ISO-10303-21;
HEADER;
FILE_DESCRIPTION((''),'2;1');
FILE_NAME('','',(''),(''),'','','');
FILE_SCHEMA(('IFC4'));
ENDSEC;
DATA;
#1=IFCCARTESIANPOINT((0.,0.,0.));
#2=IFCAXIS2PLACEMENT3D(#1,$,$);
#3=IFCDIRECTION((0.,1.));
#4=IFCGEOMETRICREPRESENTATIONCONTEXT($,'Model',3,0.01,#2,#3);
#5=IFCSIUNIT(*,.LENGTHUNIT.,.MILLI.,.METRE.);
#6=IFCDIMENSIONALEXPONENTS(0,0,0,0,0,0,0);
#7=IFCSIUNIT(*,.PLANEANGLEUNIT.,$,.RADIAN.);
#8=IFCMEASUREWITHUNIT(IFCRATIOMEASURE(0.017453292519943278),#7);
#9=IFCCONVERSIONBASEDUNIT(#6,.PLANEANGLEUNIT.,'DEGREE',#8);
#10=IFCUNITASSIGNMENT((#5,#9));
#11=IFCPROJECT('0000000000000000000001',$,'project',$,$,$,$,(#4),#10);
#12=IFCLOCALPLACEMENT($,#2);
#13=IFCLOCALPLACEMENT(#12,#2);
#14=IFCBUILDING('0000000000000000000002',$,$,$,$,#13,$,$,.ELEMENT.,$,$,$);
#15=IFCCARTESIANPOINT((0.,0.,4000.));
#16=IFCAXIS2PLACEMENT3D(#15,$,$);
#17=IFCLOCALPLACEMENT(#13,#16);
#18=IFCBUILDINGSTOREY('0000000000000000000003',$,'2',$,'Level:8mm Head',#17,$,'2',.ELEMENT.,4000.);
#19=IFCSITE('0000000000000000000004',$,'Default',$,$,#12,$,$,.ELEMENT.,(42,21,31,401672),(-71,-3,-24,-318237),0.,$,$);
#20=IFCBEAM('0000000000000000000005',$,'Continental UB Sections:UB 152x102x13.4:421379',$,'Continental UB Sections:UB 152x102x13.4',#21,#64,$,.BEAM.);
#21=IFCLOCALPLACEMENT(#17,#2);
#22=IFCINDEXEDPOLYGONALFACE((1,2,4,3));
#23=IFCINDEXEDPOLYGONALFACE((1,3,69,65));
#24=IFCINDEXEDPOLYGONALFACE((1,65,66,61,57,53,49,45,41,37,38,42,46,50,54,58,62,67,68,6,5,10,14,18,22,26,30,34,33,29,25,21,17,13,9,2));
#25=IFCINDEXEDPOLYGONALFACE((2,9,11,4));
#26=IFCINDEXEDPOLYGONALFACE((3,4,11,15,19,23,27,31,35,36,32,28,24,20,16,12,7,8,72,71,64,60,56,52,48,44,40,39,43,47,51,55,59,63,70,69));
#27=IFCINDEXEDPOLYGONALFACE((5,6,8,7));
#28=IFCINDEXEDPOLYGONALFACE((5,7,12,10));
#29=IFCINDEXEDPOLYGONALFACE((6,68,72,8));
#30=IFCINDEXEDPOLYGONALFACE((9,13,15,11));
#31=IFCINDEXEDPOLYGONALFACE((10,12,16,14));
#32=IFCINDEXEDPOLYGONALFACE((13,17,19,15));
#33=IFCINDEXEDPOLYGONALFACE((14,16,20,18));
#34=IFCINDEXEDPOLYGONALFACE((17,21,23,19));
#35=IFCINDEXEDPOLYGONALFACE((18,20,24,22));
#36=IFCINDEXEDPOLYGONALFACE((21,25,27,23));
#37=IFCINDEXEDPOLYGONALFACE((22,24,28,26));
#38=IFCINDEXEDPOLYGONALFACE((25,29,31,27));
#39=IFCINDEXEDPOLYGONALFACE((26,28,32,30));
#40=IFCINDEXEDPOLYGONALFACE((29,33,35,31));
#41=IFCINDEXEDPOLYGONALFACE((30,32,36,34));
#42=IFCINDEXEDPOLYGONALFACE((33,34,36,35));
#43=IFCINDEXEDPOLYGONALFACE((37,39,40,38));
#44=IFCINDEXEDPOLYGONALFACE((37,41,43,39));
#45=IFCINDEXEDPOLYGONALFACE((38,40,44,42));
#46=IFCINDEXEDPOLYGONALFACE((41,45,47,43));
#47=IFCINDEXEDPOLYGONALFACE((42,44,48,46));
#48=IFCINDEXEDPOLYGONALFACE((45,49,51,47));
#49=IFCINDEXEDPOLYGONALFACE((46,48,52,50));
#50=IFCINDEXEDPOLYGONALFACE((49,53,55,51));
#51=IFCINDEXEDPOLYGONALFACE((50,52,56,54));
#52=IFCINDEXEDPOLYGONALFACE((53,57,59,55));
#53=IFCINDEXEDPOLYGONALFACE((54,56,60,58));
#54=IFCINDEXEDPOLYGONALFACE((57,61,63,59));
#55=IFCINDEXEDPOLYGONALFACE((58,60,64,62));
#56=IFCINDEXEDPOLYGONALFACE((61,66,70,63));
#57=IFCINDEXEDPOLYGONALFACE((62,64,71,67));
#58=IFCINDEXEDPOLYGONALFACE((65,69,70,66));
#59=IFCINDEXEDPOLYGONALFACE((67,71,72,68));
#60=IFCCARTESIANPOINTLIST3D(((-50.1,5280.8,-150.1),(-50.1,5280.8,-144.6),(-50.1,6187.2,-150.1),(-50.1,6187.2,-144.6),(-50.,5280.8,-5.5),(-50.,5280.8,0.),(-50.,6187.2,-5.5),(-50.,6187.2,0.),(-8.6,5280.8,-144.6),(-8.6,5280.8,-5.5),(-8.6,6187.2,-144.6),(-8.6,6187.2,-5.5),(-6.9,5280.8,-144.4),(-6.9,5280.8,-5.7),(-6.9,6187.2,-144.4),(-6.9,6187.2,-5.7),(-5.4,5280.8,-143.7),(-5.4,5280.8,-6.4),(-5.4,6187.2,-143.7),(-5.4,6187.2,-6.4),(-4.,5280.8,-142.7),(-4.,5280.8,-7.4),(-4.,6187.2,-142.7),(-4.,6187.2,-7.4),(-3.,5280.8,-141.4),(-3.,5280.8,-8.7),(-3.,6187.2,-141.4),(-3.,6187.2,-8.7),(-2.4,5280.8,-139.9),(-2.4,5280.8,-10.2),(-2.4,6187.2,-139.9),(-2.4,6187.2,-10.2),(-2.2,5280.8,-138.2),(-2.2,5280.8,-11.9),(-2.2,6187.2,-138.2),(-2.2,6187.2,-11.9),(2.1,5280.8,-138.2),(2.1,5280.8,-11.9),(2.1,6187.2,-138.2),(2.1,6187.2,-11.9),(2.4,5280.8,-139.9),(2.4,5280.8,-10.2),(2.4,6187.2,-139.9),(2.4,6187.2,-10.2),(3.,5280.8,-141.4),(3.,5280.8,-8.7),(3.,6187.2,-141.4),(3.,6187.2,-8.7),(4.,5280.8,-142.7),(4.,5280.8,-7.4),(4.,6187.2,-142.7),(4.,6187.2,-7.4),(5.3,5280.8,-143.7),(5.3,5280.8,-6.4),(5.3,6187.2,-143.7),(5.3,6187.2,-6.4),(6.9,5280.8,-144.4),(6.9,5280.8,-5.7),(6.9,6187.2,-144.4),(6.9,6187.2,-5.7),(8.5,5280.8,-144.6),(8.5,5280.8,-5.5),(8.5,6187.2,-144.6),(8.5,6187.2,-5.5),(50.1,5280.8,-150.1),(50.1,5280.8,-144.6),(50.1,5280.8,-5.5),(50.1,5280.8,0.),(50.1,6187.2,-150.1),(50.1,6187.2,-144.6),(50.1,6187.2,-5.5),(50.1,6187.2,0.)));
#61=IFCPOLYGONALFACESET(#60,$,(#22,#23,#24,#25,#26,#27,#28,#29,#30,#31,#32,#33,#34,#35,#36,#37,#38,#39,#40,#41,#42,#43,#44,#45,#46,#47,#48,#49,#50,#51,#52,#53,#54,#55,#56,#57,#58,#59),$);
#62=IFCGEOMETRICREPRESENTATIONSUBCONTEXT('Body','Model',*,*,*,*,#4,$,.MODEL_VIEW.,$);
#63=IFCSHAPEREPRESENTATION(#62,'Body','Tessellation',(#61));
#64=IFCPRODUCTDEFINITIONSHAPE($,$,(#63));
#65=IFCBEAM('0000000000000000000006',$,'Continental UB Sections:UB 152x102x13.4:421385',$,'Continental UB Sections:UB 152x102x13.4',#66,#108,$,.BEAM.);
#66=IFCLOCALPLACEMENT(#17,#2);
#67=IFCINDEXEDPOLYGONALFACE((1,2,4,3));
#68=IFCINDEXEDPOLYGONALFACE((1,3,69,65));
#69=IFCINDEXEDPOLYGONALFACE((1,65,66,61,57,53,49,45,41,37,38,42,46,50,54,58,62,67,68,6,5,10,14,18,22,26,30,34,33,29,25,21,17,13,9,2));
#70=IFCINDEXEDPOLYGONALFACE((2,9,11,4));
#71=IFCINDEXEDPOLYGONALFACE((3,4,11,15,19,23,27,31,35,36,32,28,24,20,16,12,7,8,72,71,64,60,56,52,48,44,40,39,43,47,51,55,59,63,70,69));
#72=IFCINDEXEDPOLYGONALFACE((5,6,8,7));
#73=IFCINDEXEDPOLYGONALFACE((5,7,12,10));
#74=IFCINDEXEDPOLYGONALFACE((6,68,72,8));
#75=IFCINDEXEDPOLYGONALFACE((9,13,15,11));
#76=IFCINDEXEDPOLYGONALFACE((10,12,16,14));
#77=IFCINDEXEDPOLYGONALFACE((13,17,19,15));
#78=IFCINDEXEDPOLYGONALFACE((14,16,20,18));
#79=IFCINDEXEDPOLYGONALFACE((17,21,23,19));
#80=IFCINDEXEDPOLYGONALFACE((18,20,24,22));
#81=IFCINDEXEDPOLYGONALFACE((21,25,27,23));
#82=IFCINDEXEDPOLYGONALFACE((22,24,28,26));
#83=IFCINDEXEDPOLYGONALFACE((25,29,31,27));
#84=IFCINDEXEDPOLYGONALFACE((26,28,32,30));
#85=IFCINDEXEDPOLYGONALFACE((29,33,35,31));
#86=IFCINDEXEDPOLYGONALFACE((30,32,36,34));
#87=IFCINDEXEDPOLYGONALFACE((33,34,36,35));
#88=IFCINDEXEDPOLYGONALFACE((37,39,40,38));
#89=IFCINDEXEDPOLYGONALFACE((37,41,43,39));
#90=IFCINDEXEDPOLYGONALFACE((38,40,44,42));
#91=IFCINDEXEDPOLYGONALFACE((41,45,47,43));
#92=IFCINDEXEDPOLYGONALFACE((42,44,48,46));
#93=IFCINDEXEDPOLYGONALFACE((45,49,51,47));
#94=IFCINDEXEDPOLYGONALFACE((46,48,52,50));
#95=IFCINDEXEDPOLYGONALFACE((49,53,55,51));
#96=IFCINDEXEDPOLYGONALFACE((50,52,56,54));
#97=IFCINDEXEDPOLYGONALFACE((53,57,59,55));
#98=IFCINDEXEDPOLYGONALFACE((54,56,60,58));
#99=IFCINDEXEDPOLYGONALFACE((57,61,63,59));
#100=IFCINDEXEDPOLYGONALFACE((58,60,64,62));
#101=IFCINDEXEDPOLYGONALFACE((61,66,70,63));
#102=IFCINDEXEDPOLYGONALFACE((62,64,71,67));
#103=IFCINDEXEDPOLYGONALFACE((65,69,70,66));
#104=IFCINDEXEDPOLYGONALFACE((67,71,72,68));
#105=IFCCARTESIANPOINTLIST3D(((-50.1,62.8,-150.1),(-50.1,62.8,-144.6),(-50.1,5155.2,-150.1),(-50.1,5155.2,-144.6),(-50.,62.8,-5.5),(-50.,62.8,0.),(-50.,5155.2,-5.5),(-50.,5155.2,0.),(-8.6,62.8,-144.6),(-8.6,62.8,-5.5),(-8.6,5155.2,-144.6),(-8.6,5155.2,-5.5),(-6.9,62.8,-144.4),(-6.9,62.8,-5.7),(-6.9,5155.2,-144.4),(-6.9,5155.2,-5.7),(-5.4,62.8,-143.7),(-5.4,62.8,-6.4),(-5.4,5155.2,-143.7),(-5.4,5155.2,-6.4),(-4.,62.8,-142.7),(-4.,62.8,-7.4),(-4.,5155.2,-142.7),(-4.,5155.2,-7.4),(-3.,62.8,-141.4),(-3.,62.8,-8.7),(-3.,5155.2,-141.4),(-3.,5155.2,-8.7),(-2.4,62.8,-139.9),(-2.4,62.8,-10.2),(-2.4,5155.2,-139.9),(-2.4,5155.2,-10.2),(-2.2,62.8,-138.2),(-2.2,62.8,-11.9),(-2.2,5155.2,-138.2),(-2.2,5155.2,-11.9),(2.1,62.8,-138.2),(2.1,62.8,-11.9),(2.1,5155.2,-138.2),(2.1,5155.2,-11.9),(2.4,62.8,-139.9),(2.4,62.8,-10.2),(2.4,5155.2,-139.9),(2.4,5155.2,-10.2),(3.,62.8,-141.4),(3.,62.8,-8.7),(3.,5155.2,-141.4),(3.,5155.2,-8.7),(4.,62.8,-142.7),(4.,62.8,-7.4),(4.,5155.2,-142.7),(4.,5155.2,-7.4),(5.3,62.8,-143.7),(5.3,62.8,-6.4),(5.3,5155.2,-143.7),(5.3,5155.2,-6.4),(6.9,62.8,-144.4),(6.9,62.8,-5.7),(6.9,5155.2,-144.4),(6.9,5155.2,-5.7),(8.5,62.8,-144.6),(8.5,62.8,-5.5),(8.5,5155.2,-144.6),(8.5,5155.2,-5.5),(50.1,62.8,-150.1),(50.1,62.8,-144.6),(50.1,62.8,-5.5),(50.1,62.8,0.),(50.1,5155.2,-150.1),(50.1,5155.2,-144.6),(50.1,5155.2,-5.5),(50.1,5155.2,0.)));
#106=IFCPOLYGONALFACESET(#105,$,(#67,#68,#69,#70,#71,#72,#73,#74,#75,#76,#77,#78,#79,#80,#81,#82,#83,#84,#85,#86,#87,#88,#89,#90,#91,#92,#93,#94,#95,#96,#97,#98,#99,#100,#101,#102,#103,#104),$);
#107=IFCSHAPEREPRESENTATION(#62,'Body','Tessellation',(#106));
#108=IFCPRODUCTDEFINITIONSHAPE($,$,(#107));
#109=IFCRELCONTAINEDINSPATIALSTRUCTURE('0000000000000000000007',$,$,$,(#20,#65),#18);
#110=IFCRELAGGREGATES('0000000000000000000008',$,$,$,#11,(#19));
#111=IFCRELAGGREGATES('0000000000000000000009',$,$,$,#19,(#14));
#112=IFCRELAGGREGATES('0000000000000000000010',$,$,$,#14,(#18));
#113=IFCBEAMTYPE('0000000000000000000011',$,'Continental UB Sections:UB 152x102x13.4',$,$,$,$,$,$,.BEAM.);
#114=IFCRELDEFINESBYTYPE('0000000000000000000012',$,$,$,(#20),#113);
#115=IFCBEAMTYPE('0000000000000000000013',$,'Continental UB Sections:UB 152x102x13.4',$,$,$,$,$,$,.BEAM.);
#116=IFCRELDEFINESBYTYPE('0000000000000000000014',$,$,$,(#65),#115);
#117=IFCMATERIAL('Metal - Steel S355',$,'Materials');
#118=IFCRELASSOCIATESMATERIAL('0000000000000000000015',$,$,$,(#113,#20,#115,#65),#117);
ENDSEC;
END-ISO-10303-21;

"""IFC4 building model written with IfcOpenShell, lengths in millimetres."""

from ifc_helpers import new_model, entity, si_unit, converted_unit, direction, frame, origin, place, context, subcontext, project, spatial, line, arc, indexed_curve, outline, extrude, source, transform, mapped, material, type_object, type_shapes, element, save


model = new_model("IFC4")

# Units and contexts
model_context = context("Model", 3, precision=0.01, world=origin(), true_north=direction((0.0, 1.0)))
body_context = subcontext(model_context, "Body", "Model", "MODEL_VIEW")
ifc_project = project(units=[si_unit("LENGTHUNIT", "METRE", prefix="MILLI"), converted_unit("PLANEANGLEUNIT", "DEGREE", entity("IfcRatioMeasure", 0.017453292519943278), si_unit("PLANEANGLEUNIT", "RADIAN"), dimensions=[0, 0, 0, 0, 0, 0, 0])], contexts=[model_context])

# Site, building, storey
site_placement = place(None, origin())
site = spatial("IfcSite", under=ifc_project, at=site_placement, Name="Default", CompositionType="ELEMENT", RefLatitude=(42, 21, 31, 401672), RefLongitude=(-71, -3, -24, -318237), RefElevation=0.0)
building_placement = place(site_placement, origin())
building = spatial("IfcBuilding", under=site, at=building_placement, CompositionType="ELEMENT")
storey_placement = place(building_placement, frame((0.0, 0.0, 4000.0)))
storey = spatial("IfcBuildingStorey", under=building, at=storey_placement, Name="2", ObjectType="Level:8mm Head", LongName="2", CompositionType="ELEMENT", Elevation=4000.0)

# Beams
ifc_material = material(Name="Metal - Steel S355", Category="Materials")
beam_type_1 = type_object("IfcBeamType", Name="Continental UB Sections:UB 152x102x13.4", PredefinedType="BEAM", material=ifc_material)
shared_shape_1 = source(origin(), body_context, "Body", "SweptSolid", [
    extrude(outline(indexed_curve([(-75.0, -50.1), (-69.6, -50.1), (-69.6, -8.5), (-67.7, -4.0), (-63.2, -2.1), (63.1, -2.1), (67.7, -4.0), (69.5, -8.5), (69.5, -50.1), (75.1, -50.1), (75.1, 50.1), (69.5, 50.1), (69.5, 8.6), (67.7, 4.0), (63.1, 2.2), (-63.2, 2.2), (-67.7, 4.0), (-69.6, 8.6), (-69.6, 50.0), (-75.0, 50.0)], segments=[line(1, 2, 3), arc(3, 4, 5), line(5, 6), arc(6, 7, 8), line(8, 9, 10, 11, 12, 13), arc(13, 14, 15), line(15, 16), arc(16, 17, 18), line(18, 19, 20, 1)], self_intersect=False)), frame((-453.2, 0.0, 0.0), z_axis=(1.0, 0.0, 0.0), x_axis=(0.0, 0.0, -1.0)), (0.0, 0.0, 1.0), 906.4),
])
type_shapes(beam_type_1, [shared_shape_1])
beam_1_placement = place(storey_placement, frame((0.0, 5734.0, -75.1), z_axis=(0.0, 0.0, 1.0), x_axis=(0.0, 1.0, 0.0)))
element("IfcBeam", 1, at=beam_1_placement, inside=storey, type_object=beam_type_1, material=ifc_material, Name="Continental UB Sections:UB 152x102x13.4:421379", ObjectType="Continental UB Sections:UB 152x102x13.4", PredefinedType="BEAM", context=body_context, shape_type="MappedRepresentation", body=[
    mapped(shared_shape_1, transform((0.0, 0.0, 0.0), scale=1.0)),
])
beam_type_2 = type_object("IfcBeamType", Name="Continental UB Sections:UB 152x102x13.4", PredefinedType="BEAM", material=ifc_material)
shared_shape_2 = source(origin(), body_context, "Body", "SweptSolid", [
    extrude(outline(indexed_curve([(-75.0, -50.1), (-69.6, -50.1), (-69.6, -8.5), (-67.7, -4.0), (-63.2, -2.1), (63.1, -2.1), (67.7, -4.0), (69.5, -8.5), (69.5, -50.1), (75.1, -50.1), (75.1, 50.1), (69.5, 50.1), (69.5, 8.6), (67.7, 4.0), (63.1, 2.2), (-63.2, 2.2), (-67.7, 4.0), (-69.6, 8.6), (-69.6, 50.0), (-75.0, 50.0)], segments=[line(1, 2, 3), arc(3, 4, 5), line(5, 6), arc(6, 7, 8), line(8, 9, 10, 11, 12, 13), arc(13, 14, 15), line(15, 16), arc(16, 17, 18), line(18, 19, 20, 1)], self_intersect=False)), frame((-2546.2, 0.0, 0.0), z_axis=(1.0, 0.0, 0.0), x_axis=(0.0, 0.0, -1.0)), (0.0, 0.0, 1.0), 5092.4),
])
type_shapes(beam_type_2, [shared_shape_2])
beam_2_placement = place(storey_placement, frame((0.0, 2609.0, -75.1), z_axis=(0.0, 0.0, 1.0), x_axis=(0.0, 1.0, 0.0)))
element("IfcBeam", 2, at=beam_2_placement, inside=storey, type_object=beam_type_2, material=ifc_material, Name="Continental UB Sections:UB 152x102x13.4:421385", ObjectType="Continental UB Sections:UB 152x102x13.4", PredefinedType="BEAM", context=body_context, shape_type="MappedRepresentation", body=[
    mapped(shared_shape_2, transform((0.0, 0.0, 0.0), scale=1.0)),
])

save(model, "model.ifc")
